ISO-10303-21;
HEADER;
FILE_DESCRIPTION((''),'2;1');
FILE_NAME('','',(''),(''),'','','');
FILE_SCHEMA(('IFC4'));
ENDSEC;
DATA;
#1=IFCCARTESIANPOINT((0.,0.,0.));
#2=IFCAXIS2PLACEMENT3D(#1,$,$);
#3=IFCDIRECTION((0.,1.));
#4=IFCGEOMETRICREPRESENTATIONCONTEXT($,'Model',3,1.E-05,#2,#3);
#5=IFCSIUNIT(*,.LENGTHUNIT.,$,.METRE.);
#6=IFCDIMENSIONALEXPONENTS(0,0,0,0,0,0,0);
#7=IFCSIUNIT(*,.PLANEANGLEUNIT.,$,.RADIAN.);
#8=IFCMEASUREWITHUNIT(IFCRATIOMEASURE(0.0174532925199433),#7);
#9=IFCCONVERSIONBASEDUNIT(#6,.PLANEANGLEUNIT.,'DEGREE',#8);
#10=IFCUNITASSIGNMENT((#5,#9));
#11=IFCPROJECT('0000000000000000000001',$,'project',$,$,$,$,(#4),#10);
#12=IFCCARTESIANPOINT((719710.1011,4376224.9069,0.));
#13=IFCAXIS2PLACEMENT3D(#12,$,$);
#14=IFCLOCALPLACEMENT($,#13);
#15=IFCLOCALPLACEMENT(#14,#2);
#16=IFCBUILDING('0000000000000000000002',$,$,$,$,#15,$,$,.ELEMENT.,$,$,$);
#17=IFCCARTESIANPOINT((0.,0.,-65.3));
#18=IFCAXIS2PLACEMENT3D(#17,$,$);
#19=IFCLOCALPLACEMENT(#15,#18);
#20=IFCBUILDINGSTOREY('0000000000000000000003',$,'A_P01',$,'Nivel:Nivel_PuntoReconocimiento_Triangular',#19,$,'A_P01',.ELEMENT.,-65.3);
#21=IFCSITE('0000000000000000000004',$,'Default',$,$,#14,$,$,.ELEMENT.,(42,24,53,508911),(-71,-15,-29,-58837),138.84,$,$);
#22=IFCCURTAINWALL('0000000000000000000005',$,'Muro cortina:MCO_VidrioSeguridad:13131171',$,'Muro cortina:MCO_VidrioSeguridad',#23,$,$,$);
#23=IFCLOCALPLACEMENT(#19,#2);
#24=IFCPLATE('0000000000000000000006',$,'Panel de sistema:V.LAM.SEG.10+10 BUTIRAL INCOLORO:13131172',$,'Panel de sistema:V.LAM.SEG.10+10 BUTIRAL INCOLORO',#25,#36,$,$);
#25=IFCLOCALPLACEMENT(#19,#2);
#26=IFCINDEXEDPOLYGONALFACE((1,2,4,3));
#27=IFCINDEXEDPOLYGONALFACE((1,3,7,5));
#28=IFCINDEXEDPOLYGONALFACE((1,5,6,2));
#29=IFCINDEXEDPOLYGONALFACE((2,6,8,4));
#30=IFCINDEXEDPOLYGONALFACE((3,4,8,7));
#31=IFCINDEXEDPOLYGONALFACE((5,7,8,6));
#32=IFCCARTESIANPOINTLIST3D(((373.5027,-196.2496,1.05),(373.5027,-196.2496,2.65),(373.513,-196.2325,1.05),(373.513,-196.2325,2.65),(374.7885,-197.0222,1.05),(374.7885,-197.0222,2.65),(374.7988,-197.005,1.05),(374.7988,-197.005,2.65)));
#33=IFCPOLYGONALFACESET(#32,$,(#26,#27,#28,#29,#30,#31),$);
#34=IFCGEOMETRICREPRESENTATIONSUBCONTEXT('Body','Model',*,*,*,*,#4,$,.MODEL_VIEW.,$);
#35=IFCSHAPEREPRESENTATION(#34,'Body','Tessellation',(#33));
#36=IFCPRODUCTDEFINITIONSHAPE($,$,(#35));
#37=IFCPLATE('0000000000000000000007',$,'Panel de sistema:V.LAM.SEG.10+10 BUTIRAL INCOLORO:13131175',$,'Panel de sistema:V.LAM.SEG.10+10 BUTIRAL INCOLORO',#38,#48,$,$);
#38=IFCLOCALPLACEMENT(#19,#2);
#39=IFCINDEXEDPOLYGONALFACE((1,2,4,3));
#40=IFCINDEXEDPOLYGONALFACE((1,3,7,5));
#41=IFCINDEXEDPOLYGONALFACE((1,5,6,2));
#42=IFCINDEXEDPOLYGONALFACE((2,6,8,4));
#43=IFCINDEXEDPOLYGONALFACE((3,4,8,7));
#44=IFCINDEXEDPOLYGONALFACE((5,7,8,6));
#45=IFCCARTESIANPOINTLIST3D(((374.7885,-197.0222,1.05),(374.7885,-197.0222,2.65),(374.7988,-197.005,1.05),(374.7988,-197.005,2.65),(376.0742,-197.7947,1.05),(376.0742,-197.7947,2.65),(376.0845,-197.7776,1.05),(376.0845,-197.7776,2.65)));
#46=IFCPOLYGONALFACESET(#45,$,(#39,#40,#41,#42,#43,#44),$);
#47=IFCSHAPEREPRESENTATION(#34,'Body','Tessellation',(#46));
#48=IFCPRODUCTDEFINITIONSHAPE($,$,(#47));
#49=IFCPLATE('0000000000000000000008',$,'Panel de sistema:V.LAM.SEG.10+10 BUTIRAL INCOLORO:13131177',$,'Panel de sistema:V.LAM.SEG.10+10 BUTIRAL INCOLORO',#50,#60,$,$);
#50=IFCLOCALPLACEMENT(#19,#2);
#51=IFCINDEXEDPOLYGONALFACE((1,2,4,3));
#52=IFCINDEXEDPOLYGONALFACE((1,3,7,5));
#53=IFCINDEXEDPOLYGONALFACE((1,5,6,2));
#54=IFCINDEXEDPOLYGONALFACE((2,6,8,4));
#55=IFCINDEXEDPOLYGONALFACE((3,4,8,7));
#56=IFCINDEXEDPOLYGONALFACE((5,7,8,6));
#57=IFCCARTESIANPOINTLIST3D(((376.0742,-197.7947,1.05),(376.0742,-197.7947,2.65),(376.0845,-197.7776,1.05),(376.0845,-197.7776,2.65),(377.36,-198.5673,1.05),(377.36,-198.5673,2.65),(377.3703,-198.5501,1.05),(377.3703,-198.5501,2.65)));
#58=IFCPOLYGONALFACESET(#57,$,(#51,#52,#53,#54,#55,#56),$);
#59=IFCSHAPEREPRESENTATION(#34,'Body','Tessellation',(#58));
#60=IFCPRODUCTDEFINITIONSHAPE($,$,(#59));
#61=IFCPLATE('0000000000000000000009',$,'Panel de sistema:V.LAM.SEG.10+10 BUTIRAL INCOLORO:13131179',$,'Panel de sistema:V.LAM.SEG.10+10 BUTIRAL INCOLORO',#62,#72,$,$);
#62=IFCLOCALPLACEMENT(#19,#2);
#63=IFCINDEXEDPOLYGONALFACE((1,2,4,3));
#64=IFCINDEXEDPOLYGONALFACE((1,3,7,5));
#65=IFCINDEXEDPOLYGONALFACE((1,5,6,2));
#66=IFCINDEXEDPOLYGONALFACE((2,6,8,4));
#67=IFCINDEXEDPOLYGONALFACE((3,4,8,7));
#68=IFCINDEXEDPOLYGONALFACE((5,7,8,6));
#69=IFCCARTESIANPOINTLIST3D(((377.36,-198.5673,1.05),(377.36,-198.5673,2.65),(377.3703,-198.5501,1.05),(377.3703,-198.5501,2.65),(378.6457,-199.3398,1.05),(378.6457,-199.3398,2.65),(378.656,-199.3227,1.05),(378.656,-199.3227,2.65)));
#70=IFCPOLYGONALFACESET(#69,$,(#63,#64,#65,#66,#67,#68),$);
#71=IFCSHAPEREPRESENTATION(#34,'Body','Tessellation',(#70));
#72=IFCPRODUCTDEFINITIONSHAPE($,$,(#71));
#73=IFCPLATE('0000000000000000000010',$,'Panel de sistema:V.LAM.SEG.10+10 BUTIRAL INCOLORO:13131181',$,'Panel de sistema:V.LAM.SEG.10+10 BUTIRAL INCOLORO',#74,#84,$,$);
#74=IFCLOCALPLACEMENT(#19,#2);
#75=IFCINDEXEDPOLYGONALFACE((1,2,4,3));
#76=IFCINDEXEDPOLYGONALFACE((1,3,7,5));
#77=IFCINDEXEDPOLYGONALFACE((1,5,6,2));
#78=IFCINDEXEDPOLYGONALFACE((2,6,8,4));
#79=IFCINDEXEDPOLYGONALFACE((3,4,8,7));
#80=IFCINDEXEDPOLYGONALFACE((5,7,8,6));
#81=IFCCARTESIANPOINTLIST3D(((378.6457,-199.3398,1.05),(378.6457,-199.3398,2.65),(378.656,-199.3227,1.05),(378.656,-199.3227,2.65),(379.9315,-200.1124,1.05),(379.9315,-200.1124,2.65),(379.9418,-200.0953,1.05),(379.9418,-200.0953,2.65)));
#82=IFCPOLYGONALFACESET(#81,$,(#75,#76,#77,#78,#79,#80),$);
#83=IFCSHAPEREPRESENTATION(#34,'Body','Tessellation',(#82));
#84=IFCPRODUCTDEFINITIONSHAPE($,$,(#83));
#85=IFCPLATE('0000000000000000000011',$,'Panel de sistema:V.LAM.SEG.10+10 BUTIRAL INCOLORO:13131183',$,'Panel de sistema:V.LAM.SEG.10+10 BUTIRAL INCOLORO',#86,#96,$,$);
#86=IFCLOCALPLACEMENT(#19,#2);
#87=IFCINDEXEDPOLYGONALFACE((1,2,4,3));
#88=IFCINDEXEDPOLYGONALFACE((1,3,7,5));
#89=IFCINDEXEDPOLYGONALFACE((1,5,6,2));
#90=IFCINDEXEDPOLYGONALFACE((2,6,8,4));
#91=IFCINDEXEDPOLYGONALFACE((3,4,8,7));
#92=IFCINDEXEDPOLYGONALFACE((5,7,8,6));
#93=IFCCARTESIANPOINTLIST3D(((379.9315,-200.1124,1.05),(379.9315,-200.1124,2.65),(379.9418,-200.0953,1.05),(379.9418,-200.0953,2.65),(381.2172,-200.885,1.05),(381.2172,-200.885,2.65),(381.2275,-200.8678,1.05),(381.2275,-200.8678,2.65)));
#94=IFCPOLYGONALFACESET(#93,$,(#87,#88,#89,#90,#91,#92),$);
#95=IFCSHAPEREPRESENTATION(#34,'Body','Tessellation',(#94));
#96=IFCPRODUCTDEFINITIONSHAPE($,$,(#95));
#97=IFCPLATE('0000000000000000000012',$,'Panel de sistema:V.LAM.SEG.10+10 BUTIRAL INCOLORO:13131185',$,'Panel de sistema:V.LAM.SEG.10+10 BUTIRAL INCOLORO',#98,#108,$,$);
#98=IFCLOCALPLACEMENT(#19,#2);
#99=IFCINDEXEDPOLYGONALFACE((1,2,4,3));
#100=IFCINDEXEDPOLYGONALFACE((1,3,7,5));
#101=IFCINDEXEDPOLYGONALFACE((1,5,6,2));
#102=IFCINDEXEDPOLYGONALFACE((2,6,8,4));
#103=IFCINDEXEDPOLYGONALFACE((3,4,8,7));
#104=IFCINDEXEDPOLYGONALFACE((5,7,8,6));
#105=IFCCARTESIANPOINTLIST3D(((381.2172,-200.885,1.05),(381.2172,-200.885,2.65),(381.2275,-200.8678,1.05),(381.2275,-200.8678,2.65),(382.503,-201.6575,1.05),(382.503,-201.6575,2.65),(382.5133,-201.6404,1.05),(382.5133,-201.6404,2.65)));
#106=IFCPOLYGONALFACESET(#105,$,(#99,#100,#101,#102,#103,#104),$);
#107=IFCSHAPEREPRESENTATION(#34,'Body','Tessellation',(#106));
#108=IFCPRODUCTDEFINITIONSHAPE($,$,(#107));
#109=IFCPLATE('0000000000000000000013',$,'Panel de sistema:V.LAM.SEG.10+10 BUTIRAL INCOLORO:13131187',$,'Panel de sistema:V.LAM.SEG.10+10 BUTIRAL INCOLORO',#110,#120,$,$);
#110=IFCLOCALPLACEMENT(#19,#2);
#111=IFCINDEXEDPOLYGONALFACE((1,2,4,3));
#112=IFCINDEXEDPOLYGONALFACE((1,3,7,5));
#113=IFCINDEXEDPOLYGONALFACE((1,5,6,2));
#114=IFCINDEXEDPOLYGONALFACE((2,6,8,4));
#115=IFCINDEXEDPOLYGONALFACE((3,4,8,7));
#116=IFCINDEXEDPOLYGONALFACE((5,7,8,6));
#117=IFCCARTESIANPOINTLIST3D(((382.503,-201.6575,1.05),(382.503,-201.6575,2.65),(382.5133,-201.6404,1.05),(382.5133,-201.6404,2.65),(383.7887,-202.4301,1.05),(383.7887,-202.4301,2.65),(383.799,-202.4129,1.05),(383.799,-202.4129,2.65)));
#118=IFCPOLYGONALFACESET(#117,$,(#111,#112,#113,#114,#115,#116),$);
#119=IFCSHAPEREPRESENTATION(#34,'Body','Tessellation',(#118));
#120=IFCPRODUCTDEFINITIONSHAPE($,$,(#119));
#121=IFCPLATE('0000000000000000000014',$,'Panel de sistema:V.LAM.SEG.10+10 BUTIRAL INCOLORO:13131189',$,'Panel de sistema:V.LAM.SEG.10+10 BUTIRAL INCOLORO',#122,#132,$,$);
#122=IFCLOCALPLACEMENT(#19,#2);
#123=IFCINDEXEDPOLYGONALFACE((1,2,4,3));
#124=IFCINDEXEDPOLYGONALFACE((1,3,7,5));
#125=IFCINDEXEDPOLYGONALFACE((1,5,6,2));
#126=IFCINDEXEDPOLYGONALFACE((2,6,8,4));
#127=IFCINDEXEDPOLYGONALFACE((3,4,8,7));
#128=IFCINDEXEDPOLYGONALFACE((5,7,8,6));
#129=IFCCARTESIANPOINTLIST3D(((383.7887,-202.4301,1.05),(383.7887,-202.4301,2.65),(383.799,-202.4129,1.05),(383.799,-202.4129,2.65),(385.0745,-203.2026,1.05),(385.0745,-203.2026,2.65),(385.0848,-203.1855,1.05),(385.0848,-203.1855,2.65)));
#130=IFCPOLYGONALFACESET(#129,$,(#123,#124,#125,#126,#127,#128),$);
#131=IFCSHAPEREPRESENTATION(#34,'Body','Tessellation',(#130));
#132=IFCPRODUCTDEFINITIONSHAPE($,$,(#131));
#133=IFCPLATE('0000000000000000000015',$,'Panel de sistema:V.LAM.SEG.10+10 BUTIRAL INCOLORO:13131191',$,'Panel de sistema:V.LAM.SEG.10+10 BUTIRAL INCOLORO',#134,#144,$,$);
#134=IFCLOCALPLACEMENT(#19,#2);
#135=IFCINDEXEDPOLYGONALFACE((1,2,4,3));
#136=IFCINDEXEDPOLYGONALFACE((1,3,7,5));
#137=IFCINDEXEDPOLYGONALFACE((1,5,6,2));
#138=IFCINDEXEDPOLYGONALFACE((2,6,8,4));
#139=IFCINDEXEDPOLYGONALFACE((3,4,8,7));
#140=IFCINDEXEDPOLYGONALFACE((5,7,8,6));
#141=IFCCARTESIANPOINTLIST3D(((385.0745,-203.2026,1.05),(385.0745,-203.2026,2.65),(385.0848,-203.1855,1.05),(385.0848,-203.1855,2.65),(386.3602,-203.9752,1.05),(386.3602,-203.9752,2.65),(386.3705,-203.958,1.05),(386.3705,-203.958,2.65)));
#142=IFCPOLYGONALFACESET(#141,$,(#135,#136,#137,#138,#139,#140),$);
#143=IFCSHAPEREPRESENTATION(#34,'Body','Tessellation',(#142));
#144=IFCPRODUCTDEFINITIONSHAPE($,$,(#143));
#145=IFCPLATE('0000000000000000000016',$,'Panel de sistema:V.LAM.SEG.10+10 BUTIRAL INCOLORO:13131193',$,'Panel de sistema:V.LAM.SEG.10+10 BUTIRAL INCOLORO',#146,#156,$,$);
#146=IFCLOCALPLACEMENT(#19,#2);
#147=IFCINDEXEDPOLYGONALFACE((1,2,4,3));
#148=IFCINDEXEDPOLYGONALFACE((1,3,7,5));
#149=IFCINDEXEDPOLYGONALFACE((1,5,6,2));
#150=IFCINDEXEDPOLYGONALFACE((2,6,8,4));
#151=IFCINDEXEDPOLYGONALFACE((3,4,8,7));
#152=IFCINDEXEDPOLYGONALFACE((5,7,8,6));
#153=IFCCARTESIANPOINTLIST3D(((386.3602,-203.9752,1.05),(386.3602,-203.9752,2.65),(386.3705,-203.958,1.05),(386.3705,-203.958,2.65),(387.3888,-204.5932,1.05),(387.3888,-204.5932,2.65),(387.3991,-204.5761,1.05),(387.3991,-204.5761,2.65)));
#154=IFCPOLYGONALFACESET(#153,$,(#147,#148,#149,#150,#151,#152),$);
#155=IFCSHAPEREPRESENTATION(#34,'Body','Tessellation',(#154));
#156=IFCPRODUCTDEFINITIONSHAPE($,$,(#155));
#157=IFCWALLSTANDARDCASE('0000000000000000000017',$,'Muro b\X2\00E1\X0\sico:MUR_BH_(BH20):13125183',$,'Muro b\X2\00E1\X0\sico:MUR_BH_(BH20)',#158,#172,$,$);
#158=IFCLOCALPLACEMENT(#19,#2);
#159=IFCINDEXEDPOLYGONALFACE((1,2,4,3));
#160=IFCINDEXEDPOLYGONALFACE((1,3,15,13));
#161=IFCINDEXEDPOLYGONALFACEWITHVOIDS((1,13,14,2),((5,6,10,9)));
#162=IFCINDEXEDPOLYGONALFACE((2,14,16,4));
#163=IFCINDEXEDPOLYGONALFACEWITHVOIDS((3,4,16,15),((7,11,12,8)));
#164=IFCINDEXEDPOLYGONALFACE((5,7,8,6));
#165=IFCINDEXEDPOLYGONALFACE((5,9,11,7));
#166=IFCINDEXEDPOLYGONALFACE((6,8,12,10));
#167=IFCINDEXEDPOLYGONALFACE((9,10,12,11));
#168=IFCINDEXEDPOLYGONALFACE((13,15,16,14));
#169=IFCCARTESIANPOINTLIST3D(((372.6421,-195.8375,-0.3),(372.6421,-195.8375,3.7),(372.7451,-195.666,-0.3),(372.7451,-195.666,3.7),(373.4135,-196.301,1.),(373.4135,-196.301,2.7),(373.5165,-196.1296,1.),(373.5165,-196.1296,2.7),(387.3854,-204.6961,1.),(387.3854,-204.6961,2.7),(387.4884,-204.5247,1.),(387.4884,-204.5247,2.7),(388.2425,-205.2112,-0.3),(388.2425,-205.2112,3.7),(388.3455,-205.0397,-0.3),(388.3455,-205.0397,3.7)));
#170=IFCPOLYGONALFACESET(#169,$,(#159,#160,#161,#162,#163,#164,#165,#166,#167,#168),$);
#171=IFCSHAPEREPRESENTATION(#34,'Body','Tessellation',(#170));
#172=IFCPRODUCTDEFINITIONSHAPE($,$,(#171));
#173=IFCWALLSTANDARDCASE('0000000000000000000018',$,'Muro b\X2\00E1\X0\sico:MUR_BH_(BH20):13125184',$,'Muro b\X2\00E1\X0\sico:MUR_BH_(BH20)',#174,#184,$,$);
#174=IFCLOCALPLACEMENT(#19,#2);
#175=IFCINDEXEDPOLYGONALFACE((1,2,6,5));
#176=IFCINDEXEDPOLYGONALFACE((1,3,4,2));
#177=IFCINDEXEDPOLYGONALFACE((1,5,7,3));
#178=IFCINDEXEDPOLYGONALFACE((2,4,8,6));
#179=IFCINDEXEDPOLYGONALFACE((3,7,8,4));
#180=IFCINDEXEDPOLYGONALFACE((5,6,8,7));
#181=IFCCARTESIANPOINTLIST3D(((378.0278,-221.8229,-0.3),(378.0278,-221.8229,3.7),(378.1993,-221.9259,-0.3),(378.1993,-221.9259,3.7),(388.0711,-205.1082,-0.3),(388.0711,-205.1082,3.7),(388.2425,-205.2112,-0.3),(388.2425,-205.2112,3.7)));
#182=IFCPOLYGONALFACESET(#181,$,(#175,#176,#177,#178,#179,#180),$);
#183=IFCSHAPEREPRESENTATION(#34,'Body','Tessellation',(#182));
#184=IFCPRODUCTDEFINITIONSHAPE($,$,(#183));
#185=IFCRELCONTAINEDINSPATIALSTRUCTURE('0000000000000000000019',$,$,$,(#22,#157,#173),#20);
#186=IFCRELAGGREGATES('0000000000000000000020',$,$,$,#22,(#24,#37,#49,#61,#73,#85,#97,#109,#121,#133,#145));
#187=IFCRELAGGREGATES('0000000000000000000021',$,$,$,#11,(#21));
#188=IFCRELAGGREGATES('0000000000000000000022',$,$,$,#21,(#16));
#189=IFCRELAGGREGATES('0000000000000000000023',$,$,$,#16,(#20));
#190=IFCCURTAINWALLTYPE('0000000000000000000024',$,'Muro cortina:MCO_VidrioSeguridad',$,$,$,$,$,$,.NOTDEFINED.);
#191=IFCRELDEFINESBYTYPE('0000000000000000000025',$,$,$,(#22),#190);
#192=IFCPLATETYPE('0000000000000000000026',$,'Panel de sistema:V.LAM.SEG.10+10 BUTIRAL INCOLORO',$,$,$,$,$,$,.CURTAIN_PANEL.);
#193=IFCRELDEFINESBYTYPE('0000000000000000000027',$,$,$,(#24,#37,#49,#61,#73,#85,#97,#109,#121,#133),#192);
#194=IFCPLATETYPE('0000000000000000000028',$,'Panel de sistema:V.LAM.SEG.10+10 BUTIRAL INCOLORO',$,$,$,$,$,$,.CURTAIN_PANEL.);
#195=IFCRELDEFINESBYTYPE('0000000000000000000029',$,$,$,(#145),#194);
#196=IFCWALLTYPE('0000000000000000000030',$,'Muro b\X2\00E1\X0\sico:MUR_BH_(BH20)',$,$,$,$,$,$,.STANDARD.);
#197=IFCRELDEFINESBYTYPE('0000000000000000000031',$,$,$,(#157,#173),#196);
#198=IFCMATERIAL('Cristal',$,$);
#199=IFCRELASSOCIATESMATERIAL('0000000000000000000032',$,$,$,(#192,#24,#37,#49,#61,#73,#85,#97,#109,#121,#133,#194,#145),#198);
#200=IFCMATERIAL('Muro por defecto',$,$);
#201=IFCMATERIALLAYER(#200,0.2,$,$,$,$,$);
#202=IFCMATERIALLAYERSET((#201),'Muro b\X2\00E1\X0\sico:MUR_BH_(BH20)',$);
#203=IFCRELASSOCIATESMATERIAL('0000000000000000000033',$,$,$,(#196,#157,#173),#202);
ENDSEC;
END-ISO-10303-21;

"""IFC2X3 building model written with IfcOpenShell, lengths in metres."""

from ifc_helpers import new_model, entity, si_unit, converted_unit, direction, frame, frame_2d, origin, origin_2d_with_axis, place, context, subcontext, project, spatial, rectangle, extrude, source, transform, mapped, material, layer, layer_set, layer_usage, type_object, type_shapes, element, aggregate, save


model = new_model("IFC2X3")

# Units and contexts
model_context = context("Model", 3, precision=1e-05, world=origin(), true_north=direction((0.0, 1.0)))
body_context = subcontext(model_context, "Body", "Model", "MODEL_VIEW")
ifc_project = project(units=[si_unit("LENGTHUNIT", "METRE"), converted_unit("PLANEANGLEUNIT", "DEGREE", entity("IfcRatioMeasure", 0.0174532925199433), si_unit("PLANEANGLEUNIT", "RADIAN"), dimensions=[0, 0, 0, 0, 0, 0, 0])], contexts=[model_context])

# Site, building, storey
site_placement = place(None, frame((719710.1011, 4376224.9069, 0.0)))
site = spatial("IfcSite", under=ifc_project, at=site_placement, Name="Default", CompositionType="ELEMENT", RefLatitude=(42, 24, 53, 508911), RefLongitude=(-71, -15, -29, -58837), RefElevation=138.84)
building_placement = place(site_placement, origin())
building = spatial("IfcBuilding", under=site, at=building_placement, CompositionType="ELEMENT")
storey_placement = place(building_placement, frame((0.0, 0.0, -65.3)))
storey = spatial("IfcBuildingStorey", under=building, at=storey_placement, Name="A_P01", ObjectType="Nivel:Nivel_PuntoReconocimiento_Triangular", LongName="A_P01", CompositionType="ELEMENT", Elevation=-65.3)

# Curtain wall, plates
curtain_wall_type = type_object("IfcCurtainWallType", Name="Muro cortina:MCO_VidrioSeguridad", PredefinedType="NOTDEFINED")
curtain_wall_placement = place(storey_placement, frame((0.0, 0.0, 65.3)))
curtain_wall = element("IfcCurtainWall", 1, at=curtain_wall_placement, inside=storey, type_object=curtain_wall_type, Name="Muro cortina:MCO_VidrioSeguridad:13131171", ObjectType="Muro cortina:MCO_VidrioSeguridad")
ifc_material_1 = material(Name="Cristal")
plate_type_1 = type_object("IfcPlateType", Name="Panel de sistema:V.LAM.SEG.10+10 BUTIRAL INCOLORO", PredefinedType="CURTAIN_PANEL", material=ifc_material_1)
shared_shape_1 = source(origin(), body_context, "Body", "SweptSolid", [
    extrude(rectangle(XDim=0.02, YDim=1.5, at=frame_2d((0.0, 0.0), x_axis=(1.0, 0.0))), frame((0.0, 0.0, 0.0), z_axis=(0.0, 0.0, 1.0), x_axis=(0.0, 1.0, 0.0)), (0.0, 0.0, 1.0), 1.6),
])
type_shapes(plate_type_1, [shared_shape_1])
plate_1_placement = place(curtain_wall_placement, frame((374.1508, -196.6273, -64.25), z_axis=(0.0, 0.0, 1.0), x_axis=(0.857167, -0.515038, 0.0)))
plate_1 = element("IfcPlate", 2, at=plate_1_placement, type_object=plate_type_1, material=ifc_material_1, Name="Panel de sistema:V.LAM.SEG.10+10 BUTIRAL INCOLORO:13131172", ObjectType="Panel de sistema:V.LAM.SEG.10+10 BUTIRAL INCOLORO", context=body_context, shape_type="MappedRepresentation", body=[
    mapped(shared_shape_1, transform((0.0, 0.0, 0.0), scale=1.0)),
])
plate_2_placement = place(curtain_wall_placement, frame((375.4365, -197.3999, -64.25), z_axis=(0.0, 0.0, 1.0), x_axis=(0.857167, -0.515038, 0.0)))
plate_2 = element("IfcPlate", 3, at=plate_2_placement, type_object=plate_type_1, material=ifc_material_1, Name="Panel de sistema:V.LAM.SEG.10+10 BUTIRAL INCOLORO:13131175", ObjectType="Panel de sistema:V.LAM.SEG.10+10 BUTIRAL INCOLORO", context=body_context, shape_type="MappedRepresentation", body=[
    mapped(shared_shape_1, transform((0.0, 0.0, 0.0), scale=1.0)),
])
plate_3_placement = place(curtain_wall_placement, frame((376.7223, -198.1724, -64.25), z_axis=(0.0, 0.0, 1.0), x_axis=(0.857167, -0.515038, 0.0)))
plate_3 = element("IfcPlate", 4, at=plate_3_placement, type_object=plate_type_1, material=ifc_material_1, Name="Panel de sistema:V.LAM.SEG.10+10 BUTIRAL INCOLORO:13131177", ObjectType="Panel de sistema:V.LAM.SEG.10+10 BUTIRAL INCOLORO", context=body_context, shape_type="MappedRepresentation", body=[
    mapped(shared_shape_1, transform((0.0, 0.0, 0.0), scale=1.0)),
])
plate_4_placement = place(curtain_wall_placement, frame((378.008, -198.945, -64.25), z_axis=(0.0, 0.0, 1.0), x_axis=(0.857167, -0.515038, 0.0)))
plate_4 = element("IfcPlate", 5, at=plate_4_placement, type_object=plate_type_1, material=ifc_material_1, Name="Panel de sistema:V.LAM.SEG.10+10 BUTIRAL INCOLORO:13131179", ObjectType="Panel de sistema:V.LAM.SEG.10+10 BUTIRAL INCOLORO", context=body_context, shape_type="MappedRepresentation", body=[
    mapped(shared_shape_1, transform((0.0, 0.0, 0.0), scale=1.0)),
])
plate_5_placement = place(curtain_wall_placement, frame((379.2938, -199.7175, -64.25), z_axis=(0.0, 0.0, 1.0), x_axis=(0.857167, -0.515038, 0.0)))
plate_5 = element("IfcPlate", 6, at=plate_5_placement, type_object=plate_type_1, material=ifc_material_1, Name="Panel de sistema:V.LAM.SEG.10+10 BUTIRAL INCOLORO:13131181", ObjectType="Panel de sistema:V.LAM.SEG.10+10 BUTIRAL INCOLORO", context=body_context, shape_type="MappedRepresentation", body=[
    mapped(shared_shape_1, transform((0.0, 0.0, 0.0), scale=1.0)),
])
plate_6_placement = place(curtain_wall_placement, frame((380.5795, -200.4901, -64.25), z_axis=(0.0, 0.0, 1.0), x_axis=(0.857167, -0.515038, 0.0)))
plate_6 = element("IfcPlate", 7, at=plate_6_placement, type_object=plate_type_1, material=ifc_material_1, Name="Panel de sistema:V.LAM.SEG.10+10 BUTIRAL INCOLORO:13131183", ObjectType="Panel de sistema:V.LAM.SEG.10+10 BUTIRAL INCOLORO", context=body_context, shape_type="MappedRepresentation", body=[
    mapped(shared_shape_1, transform((0.0, 0.0, 0.0), scale=1.0)),
])
plate_7_placement = place(curtain_wall_placement, frame((381.8653, -201.2627, -64.25), z_axis=(0.0, 0.0, 1.0), x_axis=(0.857167, -0.515038, 0.0)))
plate_7 = element("IfcPlate", 8, at=plate_7_placement, type_object=plate_type_1, material=ifc_material_1, Name="Panel de sistema:V.LAM.SEG.10+10 BUTIRAL INCOLORO:13131185", ObjectType="Panel de sistema:V.LAM.SEG.10+10 BUTIRAL INCOLORO", context=body_context, shape_type="MappedRepresentation", body=[
    mapped(shared_shape_1, transform((0.0, 0.0, 0.0), scale=1.0)),
])
plate_8_placement = place(curtain_wall_placement, frame((383.151, -202.0352, -64.25), z_axis=(0.0, 0.0, 1.0), x_axis=(0.857167, -0.515038, 0.0)))
plate_8 = element("IfcPlate", 9, at=plate_8_placement, type_object=plate_type_1, material=ifc_material_1, Name="Panel de sistema:V.LAM.SEG.10+10 BUTIRAL INCOLORO:13131187", ObjectType="Panel de sistema:V.LAM.SEG.10+10 BUTIRAL INCOLORO", context=body_context, shape_type="MappedRepresentation", body=[
    mapped(shared_shape_1, transform((0.0, 0.0, 0.0), scale=1.0)),
])
plate_9_placement = place(curtain_wall_placement, frame((384.4368, -202.8078, -64.25), z_axis=(0.0, 0.0, 1.0), x_axis=(0.857167, -0.515038, 0.0)))
plate_9 = element("IfcPlate", 10, at=plate_9_placement, type_object=plate_type_1, material=ifc_material_1, Name="Panel de sistema:V.LAM.SEG.10+10 BUTIRAL INCOLORO:13131189", ObjectType="Panel de sistema:V.LAM.SEG.10+10 BUTIRAL INCOLORO", context=body_context, shape_type="MappedRepresentation", body=[
    mapped(shared_shape_1, transform((0.0, 0.0, 0.0), scale=1.0)),
])
plate_10_placement = place(curtain_wall_placement, frame((385.7225, -203.5803, -64.25), z_axis=(0.0, 0.0, 1.0), x_axis=(0.857167, -0.515038, 0.0)))
plate_10 = element("IfcPlate", 11, at=plate_10_placement, type_object=plate_type_1, material=ifc_material_1, Name="Panel de sistema:V.LAM.SEG.10+10 BUTIRAL INCOLORO:13131191", ObjectType="Panel de sistema:V.LAM.SEG.10+10 BUTIRAL INCOLORO", context=body_context, shape_type="MappedRepresentation", body=[
    mapped(shared_shape_1, transform((0.0, 0.0, 0.0), scale=1.0)),
])
plate_type_2 = type_object("IfcPlateType", Name="Panel de sistema:V.LAM.SEG.10+10 BUTIRAL INCOLORO", PredefinedType="CURTAIN_PANEL", material=ifc_material_1)
shared_shape_2 = source(origin(), body_context, "Body", "SweptSolid", [
    extrude(rectangle(XDim=0.02, YDim=1.2, at=origin_2d_with_axis()), frame((0.0, 0.0, 0.0), z_axis=(0.0, 0.0, 1.0), x_axis=(0.0, 1.0, 0.0)), (0.0, 0.0, 1.0), 1.6),
])
type_shapes(plate_type_2, [shared_shape_2])
plate_11_placement = place(curtain_wall_placement, frame((386.8797, -204.2756, -64.25), z_axis=(0.0, 0.0, 1.0), x_axis=(0.857167, -0.515038, 0.0)))
plate_11 = element("IfcPlate", 12, at=plate_11_placement, type_object=plate_type_2, material=ifc_material_1, Name="Panel de sistema:V.LAM.SEG.10+10 BUTIRAL INCOLORO:13131193", ObjectType="Panel de sistema:V.LAM.SEG.10+10 BUTIRAL INCOLORO", context=body_context, shape_type="MappedRepresentation", body=[
    mapped(shared_shape_2, transform((0.0, 0.0, 0.0), scale=1.0)),
])
aggregate(curtain_wall, [plate_1, plate_2, plate_3, plate_4, plate_5, plate_6, plate_7, plate_8, plate_9, plate_10, plate_11])

# Wall, opening
ifc_material_2 = material(Name="Muro por defecto")
ifc_layer = layer(ifc_material_2, 0.2)
ifc_layer_set = layer_set([ifc_layer], Name="Muro básico:MUR_BH_(BH20)")
ifc_layer_usage_1 = layer_usage(ifc_layer_set, "AXIS2", "NEGATIVE", 0.1)
wall_type = type_object("IfcWallType", Name="Muro básico:MUR_BH_(BH20)", PredefinedType="STANDARD", material=ifc_layer_set)
wall_1_placement = place(storey_placement, frame((372.6936, -195.7518, -0.3), z_axis=(0.0, 0.0, 1.0), x_axis=(0.857167, -0.515038, 0.0)))
wall_1 = element("IfcWallStandardCase", 13, at=wall_1_placement, inside=storey, type_object=wall_type, material=ifc_layer_usage_1, Name="Muro básico:MUR_BH_(BH20):13125183", ObjectType="Muro básico:MUR_BH_(BH20)", context=body_context, shape_type="SweptSolid", body=[
    extrude(rectangle(XDim=18.2, YDim=0.2, at=frame_2d((9.1, 0.0), x_axis=(-1.0, 0.0))), origin(), (0.0, 0.0, 1.0), 4.0),
])
opening_1_placement = place(wall_1_placement, origin())
element("IfcOpeningElement", 14, at=opening_1_placement, cuts=wall_1, ObjectType="Opening", context=body_context, shape_type="SweptSolid", body=[
    extrude(rectangle(XDim=1.7, YDim=16.3, at=frame_2d((0.0, 0.0), x_axis=(1.0, 0.0))), frame((9.05, -0.2524, 2.15), z_axis=(0.0, 1.0, 0.0), x_axis=(0.0, 0.0, 1.0)), (0.0, 0.0, 1.0), 0.5048),
])

# Wall
ifc_layer_usage_2 = layer_usage(ifc_layer_set, "AXIS2", "NEGATIVE", 0.1)
wall_2_placement = place(storey_placement, frame((388.1568, -205.1597, -0.3), z_axis=(0.0, 0.0, 1.0), x_axis=(-0.515038, -0.857167, 0.0)))
element("IfcWallStandardCase", 15, at=wall_2_placement, inside=storey, type_object=wall_type, material=ifc_layer_usage_2, Name="Muro básico:MUR_BH_(BH20):13125184", ObjectType="Muro básico:MUR_BH_(BH20)", context=body_context, shape_type="SweptSolid", body=[
    extrude(rectangle(XDim=19.5, YDim=0.2, at=frame_2d((9.75, 0.0), x_axis=(-1.0, 0.0))), origin(), (0.0, 0.0, 1.0), 4.0),
])

save(model, "model.ifc")
